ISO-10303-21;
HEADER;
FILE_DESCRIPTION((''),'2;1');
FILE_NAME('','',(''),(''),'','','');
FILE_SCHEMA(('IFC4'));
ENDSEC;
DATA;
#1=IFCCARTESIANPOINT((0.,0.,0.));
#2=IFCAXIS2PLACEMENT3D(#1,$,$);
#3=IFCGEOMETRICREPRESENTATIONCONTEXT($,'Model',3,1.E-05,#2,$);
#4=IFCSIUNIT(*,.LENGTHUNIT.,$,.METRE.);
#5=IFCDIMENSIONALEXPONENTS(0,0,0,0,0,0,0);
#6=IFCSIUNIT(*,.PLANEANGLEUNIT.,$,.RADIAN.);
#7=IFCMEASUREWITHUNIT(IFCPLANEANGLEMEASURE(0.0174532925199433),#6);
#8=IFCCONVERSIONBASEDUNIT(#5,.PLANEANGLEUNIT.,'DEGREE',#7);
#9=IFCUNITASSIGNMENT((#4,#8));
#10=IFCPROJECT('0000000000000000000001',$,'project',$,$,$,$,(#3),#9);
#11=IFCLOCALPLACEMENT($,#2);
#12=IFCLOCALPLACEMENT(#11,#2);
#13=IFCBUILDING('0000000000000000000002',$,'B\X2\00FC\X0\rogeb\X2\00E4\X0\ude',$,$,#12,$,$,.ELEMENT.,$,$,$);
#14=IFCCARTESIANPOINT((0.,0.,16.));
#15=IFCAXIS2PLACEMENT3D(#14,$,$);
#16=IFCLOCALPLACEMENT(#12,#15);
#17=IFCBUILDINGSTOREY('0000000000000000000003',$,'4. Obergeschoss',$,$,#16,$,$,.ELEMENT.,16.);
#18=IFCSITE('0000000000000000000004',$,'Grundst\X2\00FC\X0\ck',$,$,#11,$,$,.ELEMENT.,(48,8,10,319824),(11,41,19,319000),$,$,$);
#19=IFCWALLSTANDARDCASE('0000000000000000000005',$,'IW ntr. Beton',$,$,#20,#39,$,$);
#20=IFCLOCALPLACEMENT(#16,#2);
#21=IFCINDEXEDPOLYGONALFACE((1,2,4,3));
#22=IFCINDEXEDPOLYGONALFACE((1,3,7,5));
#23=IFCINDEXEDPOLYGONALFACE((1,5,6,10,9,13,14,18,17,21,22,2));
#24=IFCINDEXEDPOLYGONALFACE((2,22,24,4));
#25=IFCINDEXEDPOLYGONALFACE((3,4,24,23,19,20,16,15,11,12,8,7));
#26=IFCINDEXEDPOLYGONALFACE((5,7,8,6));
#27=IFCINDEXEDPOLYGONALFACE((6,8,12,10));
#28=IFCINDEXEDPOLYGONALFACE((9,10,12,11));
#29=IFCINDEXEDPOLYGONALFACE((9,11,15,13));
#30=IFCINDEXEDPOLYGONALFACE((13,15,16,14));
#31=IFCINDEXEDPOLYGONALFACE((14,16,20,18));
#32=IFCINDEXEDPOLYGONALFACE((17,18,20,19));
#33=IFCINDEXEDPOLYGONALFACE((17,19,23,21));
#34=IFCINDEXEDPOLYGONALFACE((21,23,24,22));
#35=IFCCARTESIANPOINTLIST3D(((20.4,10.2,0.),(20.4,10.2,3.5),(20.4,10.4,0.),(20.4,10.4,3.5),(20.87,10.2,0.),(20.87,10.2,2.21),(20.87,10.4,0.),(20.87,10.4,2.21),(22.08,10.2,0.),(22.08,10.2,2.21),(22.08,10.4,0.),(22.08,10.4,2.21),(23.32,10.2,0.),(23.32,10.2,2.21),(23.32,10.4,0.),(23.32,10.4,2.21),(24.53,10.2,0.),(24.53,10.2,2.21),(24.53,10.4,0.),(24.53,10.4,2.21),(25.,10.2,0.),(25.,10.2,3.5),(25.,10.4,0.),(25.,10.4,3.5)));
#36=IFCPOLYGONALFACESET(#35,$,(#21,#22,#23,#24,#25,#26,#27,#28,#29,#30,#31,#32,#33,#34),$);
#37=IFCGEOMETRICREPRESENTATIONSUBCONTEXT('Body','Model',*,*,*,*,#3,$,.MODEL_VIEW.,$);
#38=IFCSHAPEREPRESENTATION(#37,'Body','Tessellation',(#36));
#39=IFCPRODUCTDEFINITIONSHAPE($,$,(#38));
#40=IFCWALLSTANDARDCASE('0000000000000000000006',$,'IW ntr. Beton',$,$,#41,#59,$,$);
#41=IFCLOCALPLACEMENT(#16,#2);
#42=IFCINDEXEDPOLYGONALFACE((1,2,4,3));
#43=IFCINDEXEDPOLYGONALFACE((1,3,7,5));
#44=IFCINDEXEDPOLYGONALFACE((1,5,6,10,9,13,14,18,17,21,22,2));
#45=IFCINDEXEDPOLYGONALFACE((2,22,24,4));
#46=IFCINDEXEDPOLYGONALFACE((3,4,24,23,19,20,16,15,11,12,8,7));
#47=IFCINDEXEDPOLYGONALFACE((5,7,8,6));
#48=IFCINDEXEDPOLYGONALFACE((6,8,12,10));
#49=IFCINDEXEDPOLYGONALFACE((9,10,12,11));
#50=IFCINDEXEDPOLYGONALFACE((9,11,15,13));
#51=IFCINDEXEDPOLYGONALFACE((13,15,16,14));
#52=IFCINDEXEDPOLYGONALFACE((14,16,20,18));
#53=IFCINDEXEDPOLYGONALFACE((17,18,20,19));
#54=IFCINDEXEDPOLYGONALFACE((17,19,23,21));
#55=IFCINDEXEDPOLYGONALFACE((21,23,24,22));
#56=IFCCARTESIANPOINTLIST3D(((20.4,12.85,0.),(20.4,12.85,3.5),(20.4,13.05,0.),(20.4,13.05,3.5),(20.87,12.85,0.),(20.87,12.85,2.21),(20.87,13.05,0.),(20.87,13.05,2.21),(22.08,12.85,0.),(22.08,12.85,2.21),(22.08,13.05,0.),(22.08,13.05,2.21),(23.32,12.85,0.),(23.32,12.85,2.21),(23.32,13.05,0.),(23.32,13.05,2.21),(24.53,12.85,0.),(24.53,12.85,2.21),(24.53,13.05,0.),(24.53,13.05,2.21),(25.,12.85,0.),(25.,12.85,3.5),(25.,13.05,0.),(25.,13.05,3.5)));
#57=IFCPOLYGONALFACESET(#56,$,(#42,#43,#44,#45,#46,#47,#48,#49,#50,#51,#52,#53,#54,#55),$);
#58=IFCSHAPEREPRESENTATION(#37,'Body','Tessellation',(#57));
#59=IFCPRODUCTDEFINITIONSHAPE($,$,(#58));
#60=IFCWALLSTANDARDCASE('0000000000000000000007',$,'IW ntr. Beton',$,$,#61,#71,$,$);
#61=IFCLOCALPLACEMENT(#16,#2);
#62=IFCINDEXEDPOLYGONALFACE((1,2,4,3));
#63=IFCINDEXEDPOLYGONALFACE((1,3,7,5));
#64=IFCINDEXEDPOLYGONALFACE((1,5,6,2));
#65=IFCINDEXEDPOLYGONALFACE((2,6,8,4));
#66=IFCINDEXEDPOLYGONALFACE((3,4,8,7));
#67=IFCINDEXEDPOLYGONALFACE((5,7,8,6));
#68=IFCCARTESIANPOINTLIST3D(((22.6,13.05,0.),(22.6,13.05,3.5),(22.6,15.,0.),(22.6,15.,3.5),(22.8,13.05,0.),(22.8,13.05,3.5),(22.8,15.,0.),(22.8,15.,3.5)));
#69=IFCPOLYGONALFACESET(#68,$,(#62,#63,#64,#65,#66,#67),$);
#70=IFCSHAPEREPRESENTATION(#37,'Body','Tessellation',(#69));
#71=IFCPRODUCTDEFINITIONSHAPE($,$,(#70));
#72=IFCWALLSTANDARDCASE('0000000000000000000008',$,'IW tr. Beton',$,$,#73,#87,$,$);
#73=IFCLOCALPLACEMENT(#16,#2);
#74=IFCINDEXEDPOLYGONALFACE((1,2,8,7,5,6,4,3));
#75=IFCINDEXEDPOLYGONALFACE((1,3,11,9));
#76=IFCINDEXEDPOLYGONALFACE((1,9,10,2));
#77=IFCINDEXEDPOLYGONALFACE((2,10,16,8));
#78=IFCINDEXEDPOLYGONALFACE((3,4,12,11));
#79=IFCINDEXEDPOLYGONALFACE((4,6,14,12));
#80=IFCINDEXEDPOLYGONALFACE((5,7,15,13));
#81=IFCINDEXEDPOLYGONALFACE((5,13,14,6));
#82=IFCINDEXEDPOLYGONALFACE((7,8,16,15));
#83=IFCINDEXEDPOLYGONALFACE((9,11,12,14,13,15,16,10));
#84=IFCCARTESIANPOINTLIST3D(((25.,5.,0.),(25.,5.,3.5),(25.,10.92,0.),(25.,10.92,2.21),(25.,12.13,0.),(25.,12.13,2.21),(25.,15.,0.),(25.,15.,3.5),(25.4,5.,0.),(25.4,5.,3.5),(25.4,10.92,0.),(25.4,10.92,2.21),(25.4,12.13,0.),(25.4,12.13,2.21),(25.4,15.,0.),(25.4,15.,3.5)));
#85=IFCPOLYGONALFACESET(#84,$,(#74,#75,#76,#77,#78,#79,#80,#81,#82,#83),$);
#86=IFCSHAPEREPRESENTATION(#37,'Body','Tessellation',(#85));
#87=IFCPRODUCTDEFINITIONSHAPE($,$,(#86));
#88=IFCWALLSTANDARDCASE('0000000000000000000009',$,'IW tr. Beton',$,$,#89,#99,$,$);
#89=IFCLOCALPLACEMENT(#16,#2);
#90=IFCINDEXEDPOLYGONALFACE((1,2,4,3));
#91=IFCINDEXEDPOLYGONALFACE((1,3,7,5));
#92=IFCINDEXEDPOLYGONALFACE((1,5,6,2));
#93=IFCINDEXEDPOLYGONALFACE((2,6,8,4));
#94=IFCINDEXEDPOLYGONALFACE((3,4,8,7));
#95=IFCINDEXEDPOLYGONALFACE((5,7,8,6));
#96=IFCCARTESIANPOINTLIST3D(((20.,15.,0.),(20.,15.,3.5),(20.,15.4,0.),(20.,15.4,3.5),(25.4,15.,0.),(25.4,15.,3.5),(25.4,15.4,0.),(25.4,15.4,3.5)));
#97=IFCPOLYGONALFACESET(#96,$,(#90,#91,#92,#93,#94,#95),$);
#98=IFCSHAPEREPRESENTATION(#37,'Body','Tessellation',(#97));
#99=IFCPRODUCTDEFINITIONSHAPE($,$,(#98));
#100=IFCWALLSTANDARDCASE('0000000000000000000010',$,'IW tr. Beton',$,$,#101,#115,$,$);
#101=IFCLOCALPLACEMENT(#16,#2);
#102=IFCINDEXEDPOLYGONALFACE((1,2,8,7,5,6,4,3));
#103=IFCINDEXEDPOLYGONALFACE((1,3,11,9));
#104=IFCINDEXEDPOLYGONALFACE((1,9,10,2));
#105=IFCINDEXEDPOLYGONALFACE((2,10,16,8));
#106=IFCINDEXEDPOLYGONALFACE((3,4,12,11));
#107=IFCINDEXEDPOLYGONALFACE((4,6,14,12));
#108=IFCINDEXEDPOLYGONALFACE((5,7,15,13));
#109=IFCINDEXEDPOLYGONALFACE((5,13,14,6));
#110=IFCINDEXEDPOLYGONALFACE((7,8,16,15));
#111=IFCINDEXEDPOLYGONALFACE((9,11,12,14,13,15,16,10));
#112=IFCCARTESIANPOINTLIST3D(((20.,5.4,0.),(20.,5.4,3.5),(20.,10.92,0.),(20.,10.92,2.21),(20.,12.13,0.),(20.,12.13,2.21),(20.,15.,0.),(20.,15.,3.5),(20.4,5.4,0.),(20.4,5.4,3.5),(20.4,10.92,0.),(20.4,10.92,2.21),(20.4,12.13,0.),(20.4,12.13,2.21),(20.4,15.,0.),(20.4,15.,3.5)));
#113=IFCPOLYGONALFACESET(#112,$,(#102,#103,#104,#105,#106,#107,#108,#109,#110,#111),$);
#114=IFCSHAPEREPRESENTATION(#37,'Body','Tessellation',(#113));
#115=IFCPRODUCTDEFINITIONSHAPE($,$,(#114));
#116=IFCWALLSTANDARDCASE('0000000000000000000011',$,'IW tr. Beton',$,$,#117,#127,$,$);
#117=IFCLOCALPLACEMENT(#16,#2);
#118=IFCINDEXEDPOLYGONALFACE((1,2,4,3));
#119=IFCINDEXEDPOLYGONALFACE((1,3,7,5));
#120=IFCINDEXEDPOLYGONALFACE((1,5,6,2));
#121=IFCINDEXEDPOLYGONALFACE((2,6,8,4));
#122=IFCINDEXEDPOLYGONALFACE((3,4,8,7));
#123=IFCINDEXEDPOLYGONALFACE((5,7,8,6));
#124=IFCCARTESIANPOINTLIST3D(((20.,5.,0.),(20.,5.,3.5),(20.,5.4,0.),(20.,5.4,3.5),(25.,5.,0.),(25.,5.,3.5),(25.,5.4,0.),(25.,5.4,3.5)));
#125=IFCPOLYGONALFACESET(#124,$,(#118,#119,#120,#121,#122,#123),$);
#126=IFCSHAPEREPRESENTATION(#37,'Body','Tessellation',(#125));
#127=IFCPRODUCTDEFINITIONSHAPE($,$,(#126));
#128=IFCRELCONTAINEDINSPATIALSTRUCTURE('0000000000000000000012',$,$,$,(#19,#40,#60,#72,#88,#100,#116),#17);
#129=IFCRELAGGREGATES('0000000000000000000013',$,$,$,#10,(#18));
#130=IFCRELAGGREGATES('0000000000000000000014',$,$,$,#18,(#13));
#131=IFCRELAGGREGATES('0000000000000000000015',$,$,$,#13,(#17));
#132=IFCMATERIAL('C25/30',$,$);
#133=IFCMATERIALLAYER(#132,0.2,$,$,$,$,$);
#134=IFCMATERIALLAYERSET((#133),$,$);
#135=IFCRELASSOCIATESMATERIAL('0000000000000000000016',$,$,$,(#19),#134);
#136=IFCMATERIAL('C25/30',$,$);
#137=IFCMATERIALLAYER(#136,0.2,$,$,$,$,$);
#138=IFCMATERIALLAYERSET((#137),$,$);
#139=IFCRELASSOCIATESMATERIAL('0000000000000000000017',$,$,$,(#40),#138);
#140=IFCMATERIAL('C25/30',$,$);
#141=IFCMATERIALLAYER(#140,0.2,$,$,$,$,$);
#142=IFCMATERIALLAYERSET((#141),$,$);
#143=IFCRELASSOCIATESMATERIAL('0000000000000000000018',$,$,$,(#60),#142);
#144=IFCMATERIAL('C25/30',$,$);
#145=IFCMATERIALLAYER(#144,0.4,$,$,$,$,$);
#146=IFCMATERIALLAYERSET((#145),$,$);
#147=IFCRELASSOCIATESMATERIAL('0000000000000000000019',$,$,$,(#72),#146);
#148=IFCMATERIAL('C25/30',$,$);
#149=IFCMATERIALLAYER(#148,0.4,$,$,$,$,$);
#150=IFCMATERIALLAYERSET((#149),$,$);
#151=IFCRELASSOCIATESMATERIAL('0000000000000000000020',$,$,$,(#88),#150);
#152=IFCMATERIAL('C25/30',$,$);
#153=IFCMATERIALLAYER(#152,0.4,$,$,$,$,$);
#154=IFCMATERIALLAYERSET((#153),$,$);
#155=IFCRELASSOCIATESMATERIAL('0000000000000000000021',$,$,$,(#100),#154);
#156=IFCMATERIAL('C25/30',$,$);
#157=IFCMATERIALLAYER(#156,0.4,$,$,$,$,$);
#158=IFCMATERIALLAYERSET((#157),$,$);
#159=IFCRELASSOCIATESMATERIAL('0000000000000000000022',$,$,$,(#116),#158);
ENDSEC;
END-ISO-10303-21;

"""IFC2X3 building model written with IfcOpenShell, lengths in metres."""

from ifc_helpers import new_model, entity, si_unit, converted_unit, frame, frame_2d, origin, origin_with_axes, place, context, subcontext, project, spatial, polyline, rectangle, outline, extrude, material, layer, layer_set, layer_usage, element, save


model = new_model("IFC2X3")

# Units and contexts
model_context = context("Model", 3, precision=1e-05, world=origin())
body_context = subcontext(model_context, "Body", "Model", "MODEL_VIEW")
ifc_project = project(units=[si_unit("LENGTHUNIT", "METRE"), converted_unit("PLANEANGLEUNIT", "DEGREE", entity("IfcPlaneAngleMeasure", 0.0174532925199433), si_unit("PLANEANGLEUNIT", "RADIAN"), dimensions=[0, 0, 0, 0, 0, 0, 0])], contexts=[model_context])

# Site, building, storey
site_placement = place(None, origin())
site = spatial("IfcSite", under=ifc_project, at=site_placement, Name="Grundstück", CompositionType="ELEMENT", RefLatitude=(48, 8, 10, 319824), RefLongitude=(11, 41, 19, 319000))
building_placement = place(site_placement, origin())
building = spatial("IfcBuilding", under=site, at=building_placement, Name="Bürogebäude", CompositionType="ELEMENT")
storey_placement = place(building_placement, frame((0.0, 0.0, 16.0)))
storey = spatial("IfcBuildingStorey", under=building, at=storey_placement, Name="4. Obergeschoss", CompositionType="ELEMENT", Elevation=16.0)

# Walls, openings
ifc_material_1 = material(Name="C25/30")
ifc_layer_1 = layer(ifc_material_1, 0.2)
ifc_layer_set_1 = layer_set([ifc_layer_1])
ifc_layer_usage_1 = layer_usage(ifc_layer_set_1, "AXIS2", "POSITIVE", -0.2)
wall_1_placement = place(storey_placement, frame((25.0, 10.4, 0.0), z_axis=(0.0, 0.0, 1.0), x_axis=(-1.0, 0.0, 0.0)))
wall_1 = element("IfcWallStandardCase", 1, at=wall_1_placement, inside=storey, material=ifc_layer_usage_1, Name="IW ntr. Beton", context=body_context, shape_type="SweptSolid", body=[
    extrude(rectangle(XDim=4.6, YDim=0.2, at=frame_2d((2.3, 0.1), x_axis=(1.0, 0.0))), origin_with_axes(), (0.0, 0.0, 1.0), 3.5),
])
opening_1_placement = place(wall_1_placement, frame((4.13, 0.2, 0.0), z_axis=(0.0, -1.0, 0.0), x_axis=(0.0, 0.0, 1.0)))
element("IfcOpeningElement", 2, at=opening_1_placement, cuts=wall_1, ObjectType="Opening", context=body_context, shape_type="SweptSolid", body=[
    extrude(outline(polyline([(0.0, 1.21), (2.21, 1.21), (2.21, 0.0), (0.0, 0.0), (0.0, 1.21)])), origin_with_axes(), (0.0, 0.0, 1.0), 0.2),
])
opening_2_placement = place(wall_1_placement, frame((1.68, 0.2, 0.0), z_axis=(0.0, -1.0, 0.0), x_axis=(0.0, 0.0, 1.0)))
element("IfcOpeningElement", 3, at=opening_2_placement, cuts=wall_1, ObjectType="Opening", context=body_context, shape_type="SweptSolid", body=[
    extrude(outline(polyline([(0.0, 1.21), (2.21, 1.21), (2.21, 0.0), (0.0, 0.0), (0.0, 1.21)])), origin_with_axes(), (0.0, 0.0, 1.0), 0.2),
])
ifc_material_2 = material(Name="C25/30")
ifc_layer_2 = layer(ifc_material_2, 0.2)
ifc_layer_set_2 = layer_set([ifc_layer_2])
ifc_layer_usage_2 = layer_usage(ifc_layer_set_2, "AXIS2", "POSITIVE", -0.2)
wall_2_placement = place(storey_placement, frame((25.0, 13.05, 0.0), z_axis=(0.0, 0.0, 1.0), x_axis=(-1.0, 0.0, 0.0)))
wall_2 = element("IfcWallStandardCase", 4, at=wall_2_placement, inside=storey, material=ifc_layer_usage_2, Name="IW ntr. Beton", context=body_context, shape_type="SweptSolid", body=[
    extrude(rectangle(XDim=4.6, YDim=0.2, at=frame_2d((2.3, 0.1), x_axis=(1.0, 0.0))), origin_with_axes(), (0.0, 0.0, 1.0), 3.5),
])
opening_3_placement = place(wall_2_placement, frame((4.13, 0.2, 0.0), z_axis=(0.0, -1.0, 0.0), x_axis=(0.0, 0.0, 1.0)))
element("IfcOpeningElement", 5, at=opening_3_placement, cuts=wall_2, ObjectType="Opening", context=body_context, shape_type="SweptSolid", body=[
    extrude(outline(polyline([(0.0, 1.21), (2.21, 1.21), (2.21, 0.0), (0.0, 0.0), (0.0, 1.21)])), origin_with_axes(), (0.0, 0.0, 1.0), 0.2),
])
opening_4_placement = place(wall_2_placement, frame((1.68, 0.2, 0.0), z_axis=(0.0, -1.0, 0.0), x_axis=(0.0, 0.0, 1.0)))
element("IfcOpeningElement", 6, at=opening_4_placement, cuts=wall_2, ObjectType="Opening", context=body_context, shape_type="SweptSolid", body=[
    extrude(outline(polyline([(0.0, 1.21), (2.21, 1.21), (2.21, 0.0), (0.0, 0.0), (0.0, 1.21)])), origin_with_axes(), (0.0, 0.0, 1.0), 0.2),
])

# Wall
ifc_material_3 = material(Name="C25/30")
ifc_layer_3 = layer(ifc_material_3, 0.2)
ifc_layer_set_3 = layer_set([ifc_layer_3])
ifc_layer_usage_3 = layer_usage(ifc_layer_set_3, "AXIS2", "POSITIVE", -0.2)
wall_3_placement = place(storey_placement, frame((22.6, 15.0, 0.0), z_axis=(0.0, 0.0, 1.0), x_axis=(0.0, -1.0, 0.0)))
element("IfcWallStandardCase", 7, at=wall_3_placement, inside=storey, material=ifc_layer_usage_3, Name="IW ntr. Beton", context=body_context, shape_type="SweptSolid", body=[
    extrude(rectangle(XDim=1.95, YDim=0.2, at=frame_2d((0.975, 0.1), x_axis=(1.0, 0.0))), origin_with_axes(), (0.0, 0.0, 1.0), 3.5),
])

# Wall, opening
ifc_material_4 = material(Name="C25/30")
ifc_layer_4 = layer(ifc_material_4, 0.4)
ifc_layer_set_4 = layer_set([ifc_layer_4])
ifc_layer_usage_4 = layer_usage(ifc_layer_set_4, "AXIS2", "POSITIVE", -0.2)
wall_4_placement = place(storey_placement, frame((25.0, 15.0, 0.0), z_axis=(0.0, 0.0, 1.0), x_axis=(0.0, -1.0, 0.0)))
wall_4 = element("IfcWallStandardCase", 8, at=wall_4_placement, inside=storey, material=ifc_layer_usage_4, Name="IW tr. Beton", context=body_context, shape_type="SweptSolid", body=[
    extrude(rectangle(XDim=10.0, YDim=0.4, at=frame_2d((5.0, 0.2), x_axis=(1.0, 0.0))), origin_with_axes(), (0.0, 0.0, 1.0), 3.5),
])
opening_5_placement = place(wall_4_placement, frame((2.87, 0.0, 0.0), z_axis=(0.0, 1.0, 0.0), x_axis=(0.0, 0.0, 1.0)))
element("IfcOpeningElement", 9, at=opening_5_placement, cuts=wall_4, ObjectType="Opening", context=body_context, shape_type="SweptSolid", body=[
    extrude(outline(polyline([(0.0, 1.21), (2.21, 1.21), (2.21, 0.0), (0.0, 0.0), (0.0, 1.21)])), origin_with_axes(), (0.0, 0.0, 1.0), 0.4),
])

# Wall
ifc_material_5 = material(Name="C25/30")
ifc_layer_5 = layer(ifc_material_5, 0.4)
ifc_layer_set_5 = layer_set([ifc_layer_5])
ifc_layer_usage_5 = layer_usage(ifc_layer_set_5, "AXIS2", "POSITIVE", -0.2)
wall_5_placement = place(storey_placement, frame((20.0, 15.0, 0.0)))
element("IfcWallStandardCase", 10, at=wall_5_placement, inside=storey, material=ifc_layer_usage_5, Name="IW tr. Beton", context=body_context, shape_type="SweptSolid", body=[
    extrude(rectangle(XDim=5.4, YDim=0.4, at=frame_2d((2.7, 0.2), x_axis=(1.0, 0.0))), origin_with_axes(), (0.0, 0.0, 1.0), 3.5),
])

# Wall, opening
ifc_material_6 = material(Name="C25/30")
ifc_layer_6 = layer(ifc_material_6, 0.4)
ifc_layer_set_6 = layer_set([ifc_layer_6])
ifc_layer_usage_6 = layer_usage(ifc_layer_set_6, "AXIS2", "POSITIVE", -0.2)
wall_6_placement = place(storey_placement, frame((20.4, 5.4, 0.0), z_axis=(0.0, 0.0, 1.0), x_axis=(0.0, 1.0, 0.0)))
wall_6 = element("IfcWallStandardCase", 11, at=wall_6_placement, inside=storey, material=ifc_layer_usage_6, Name="IW tr. Beton", context=body_context, shape_type="SweptSolid", body=[
    extrude(rectangle(XDim=9.6, YDim=0.4, at=frame_2d((4.8, 0.2), x_axis=(1.0, 0.0))), origin_with_axes(), (0.0, 0.0, 1.0), 3.5),
])
opening_6_placement = place(wall_6_placement, frame((5.52, 0.0, 0.0), z_axis=(0.0, 1.0, 0.0), x_axis=(0.0, 0.0, 1.0)))
element("IfcOpeningElement", 12, at=opening_6_placement, cuts=wall_6, ObjectType="Opening", context=body_context, shape_type="SweptSolid", body=[
    extrude(outline(polyline([(0.0, 1.21), (2.21, 1.21), (2.21, 0.0), (0.0, 0.0), (0.0, 1.21)])), origin_with_axes(), (0.0, 0.0, 1.0), 0.4),
])

# Wall
ifc_material_7 = material(Name="C25/30")
ifc_layer_7 = layer(ifc_material_7, 0.4)
ifc_layer_set_7 = layer_set([ifc_layer_7])
ifc_layer_usage_7 = layer_usage(ifc_layer_set_7, "AXIS2", "POSITIVE", -0.2)
wall_7_placement = place(storey_placement, frame((25.0, 5.4, 0.0), z_axis=(0.0, 0.0, 1.0), x_axis=(-1.0, 0.0, 0.0)))
element("IfcWallStandardCase", 13, at=wall_7_placement, inside=storey, material=ifc_layer_usage_7, Name="IW tr. Beton", context=body_context, shape_type="SweptSolid", body=[
    extrude(rectangle(XDim=5.0, YDim=0.4, at=frame_2d((2.5, 0.2), x_axis=(1.0, 0.0))), origin_with_axes(), (0.0, 0.0, 1.0), 3.5),
])

save(model, "model.ifc")
